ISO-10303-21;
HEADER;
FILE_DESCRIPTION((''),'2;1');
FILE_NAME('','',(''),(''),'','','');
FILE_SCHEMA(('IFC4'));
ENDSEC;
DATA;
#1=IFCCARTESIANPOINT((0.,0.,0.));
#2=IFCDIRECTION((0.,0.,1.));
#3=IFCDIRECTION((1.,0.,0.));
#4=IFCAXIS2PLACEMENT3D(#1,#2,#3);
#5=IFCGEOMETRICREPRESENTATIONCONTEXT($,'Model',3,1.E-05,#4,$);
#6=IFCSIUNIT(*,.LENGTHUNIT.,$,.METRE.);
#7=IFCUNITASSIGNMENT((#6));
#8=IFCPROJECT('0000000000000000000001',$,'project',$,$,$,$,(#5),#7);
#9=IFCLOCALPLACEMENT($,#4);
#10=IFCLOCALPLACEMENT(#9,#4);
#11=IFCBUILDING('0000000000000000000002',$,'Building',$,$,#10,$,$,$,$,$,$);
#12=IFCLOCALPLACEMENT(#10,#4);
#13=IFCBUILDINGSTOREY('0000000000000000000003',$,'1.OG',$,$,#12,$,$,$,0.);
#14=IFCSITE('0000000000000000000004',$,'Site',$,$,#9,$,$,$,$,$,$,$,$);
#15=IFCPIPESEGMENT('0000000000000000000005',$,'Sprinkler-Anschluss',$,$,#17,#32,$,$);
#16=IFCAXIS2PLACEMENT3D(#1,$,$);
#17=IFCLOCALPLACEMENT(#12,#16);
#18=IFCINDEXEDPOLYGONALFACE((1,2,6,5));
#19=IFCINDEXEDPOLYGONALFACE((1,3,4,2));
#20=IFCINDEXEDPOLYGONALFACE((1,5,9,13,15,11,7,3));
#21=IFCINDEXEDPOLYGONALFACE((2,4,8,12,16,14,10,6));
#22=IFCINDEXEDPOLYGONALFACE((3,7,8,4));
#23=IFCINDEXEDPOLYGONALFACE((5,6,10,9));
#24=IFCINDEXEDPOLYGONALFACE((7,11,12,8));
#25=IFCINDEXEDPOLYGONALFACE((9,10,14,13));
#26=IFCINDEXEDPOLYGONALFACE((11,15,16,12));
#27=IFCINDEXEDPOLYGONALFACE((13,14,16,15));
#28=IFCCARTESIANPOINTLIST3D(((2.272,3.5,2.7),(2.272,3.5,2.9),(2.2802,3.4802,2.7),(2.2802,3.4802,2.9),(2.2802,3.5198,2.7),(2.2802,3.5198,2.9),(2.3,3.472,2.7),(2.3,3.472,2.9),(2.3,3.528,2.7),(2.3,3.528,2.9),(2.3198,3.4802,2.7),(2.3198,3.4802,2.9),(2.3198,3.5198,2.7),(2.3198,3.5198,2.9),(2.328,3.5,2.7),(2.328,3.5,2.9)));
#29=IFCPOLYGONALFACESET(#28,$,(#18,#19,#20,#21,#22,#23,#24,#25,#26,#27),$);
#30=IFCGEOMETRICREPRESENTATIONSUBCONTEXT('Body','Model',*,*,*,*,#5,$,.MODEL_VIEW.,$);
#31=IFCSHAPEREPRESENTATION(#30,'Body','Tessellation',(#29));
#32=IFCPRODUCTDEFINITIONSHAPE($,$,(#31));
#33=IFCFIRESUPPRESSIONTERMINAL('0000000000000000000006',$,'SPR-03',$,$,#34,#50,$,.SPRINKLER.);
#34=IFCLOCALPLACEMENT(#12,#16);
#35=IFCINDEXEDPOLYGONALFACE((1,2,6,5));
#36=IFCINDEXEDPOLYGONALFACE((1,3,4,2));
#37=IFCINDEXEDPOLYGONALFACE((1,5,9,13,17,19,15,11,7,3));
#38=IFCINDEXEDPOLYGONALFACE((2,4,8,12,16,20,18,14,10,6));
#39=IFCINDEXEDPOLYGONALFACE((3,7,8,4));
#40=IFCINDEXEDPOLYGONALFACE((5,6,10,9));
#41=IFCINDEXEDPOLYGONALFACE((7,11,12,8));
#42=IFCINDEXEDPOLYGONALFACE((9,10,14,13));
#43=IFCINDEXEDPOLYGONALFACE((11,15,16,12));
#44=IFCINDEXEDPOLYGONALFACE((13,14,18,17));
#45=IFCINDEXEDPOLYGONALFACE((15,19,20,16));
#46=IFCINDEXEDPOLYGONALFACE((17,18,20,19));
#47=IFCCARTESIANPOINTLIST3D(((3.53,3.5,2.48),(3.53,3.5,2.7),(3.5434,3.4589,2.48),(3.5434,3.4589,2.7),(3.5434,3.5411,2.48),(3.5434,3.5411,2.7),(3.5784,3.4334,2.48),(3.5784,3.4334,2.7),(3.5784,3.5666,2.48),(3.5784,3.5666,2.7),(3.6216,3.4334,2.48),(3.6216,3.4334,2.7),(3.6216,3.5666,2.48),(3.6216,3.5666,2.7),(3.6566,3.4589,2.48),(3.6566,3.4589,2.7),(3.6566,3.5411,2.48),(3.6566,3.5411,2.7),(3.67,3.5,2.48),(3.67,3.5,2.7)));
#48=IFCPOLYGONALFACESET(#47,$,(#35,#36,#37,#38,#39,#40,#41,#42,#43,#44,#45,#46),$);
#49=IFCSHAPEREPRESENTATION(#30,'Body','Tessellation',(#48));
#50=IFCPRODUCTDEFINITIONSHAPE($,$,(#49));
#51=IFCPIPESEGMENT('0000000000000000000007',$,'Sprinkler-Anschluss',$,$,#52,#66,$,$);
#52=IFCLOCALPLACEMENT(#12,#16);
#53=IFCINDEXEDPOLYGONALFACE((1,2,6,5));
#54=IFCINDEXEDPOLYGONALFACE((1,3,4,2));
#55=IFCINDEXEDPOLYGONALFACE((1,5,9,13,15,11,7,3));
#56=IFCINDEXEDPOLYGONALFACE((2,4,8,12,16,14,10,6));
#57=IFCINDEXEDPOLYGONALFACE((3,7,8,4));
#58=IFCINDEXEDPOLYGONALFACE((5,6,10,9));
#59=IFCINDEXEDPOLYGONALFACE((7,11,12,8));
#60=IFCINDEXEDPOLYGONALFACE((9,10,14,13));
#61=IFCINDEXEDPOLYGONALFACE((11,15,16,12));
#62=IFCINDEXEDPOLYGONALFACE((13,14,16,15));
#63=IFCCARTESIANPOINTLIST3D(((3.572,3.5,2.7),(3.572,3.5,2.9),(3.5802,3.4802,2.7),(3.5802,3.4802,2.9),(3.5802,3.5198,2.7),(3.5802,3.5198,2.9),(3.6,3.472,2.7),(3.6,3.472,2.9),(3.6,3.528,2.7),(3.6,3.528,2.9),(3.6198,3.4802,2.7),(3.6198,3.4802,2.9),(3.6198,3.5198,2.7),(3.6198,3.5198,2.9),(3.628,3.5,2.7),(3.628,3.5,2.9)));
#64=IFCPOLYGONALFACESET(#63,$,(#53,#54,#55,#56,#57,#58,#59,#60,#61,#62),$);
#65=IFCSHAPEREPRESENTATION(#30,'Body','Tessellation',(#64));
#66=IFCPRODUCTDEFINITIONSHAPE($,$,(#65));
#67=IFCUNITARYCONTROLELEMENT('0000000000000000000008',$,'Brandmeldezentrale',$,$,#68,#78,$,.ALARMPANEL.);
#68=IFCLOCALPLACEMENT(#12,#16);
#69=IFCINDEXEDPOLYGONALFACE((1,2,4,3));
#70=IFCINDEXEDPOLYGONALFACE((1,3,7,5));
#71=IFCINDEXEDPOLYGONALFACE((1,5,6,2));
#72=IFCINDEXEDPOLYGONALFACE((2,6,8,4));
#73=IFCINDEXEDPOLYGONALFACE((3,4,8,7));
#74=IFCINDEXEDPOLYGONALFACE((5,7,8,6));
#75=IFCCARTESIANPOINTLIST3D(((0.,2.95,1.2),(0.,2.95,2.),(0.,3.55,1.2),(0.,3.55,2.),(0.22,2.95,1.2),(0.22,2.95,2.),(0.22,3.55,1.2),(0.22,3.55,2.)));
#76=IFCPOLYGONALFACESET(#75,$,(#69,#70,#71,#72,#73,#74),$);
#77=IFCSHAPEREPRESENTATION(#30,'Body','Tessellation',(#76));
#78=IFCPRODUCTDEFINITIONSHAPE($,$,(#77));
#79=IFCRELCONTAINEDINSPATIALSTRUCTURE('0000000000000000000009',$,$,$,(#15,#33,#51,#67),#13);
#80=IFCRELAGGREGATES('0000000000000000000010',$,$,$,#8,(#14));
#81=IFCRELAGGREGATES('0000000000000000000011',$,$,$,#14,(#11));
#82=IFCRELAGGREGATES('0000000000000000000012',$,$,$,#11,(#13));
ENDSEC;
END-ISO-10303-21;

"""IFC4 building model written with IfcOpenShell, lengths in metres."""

from ifc_helpers import new_model, si_unit, frame, origin_with_axes, place, context, subcontext, project, spatial, polyline, outline, extrude, element, save


model = new_model("IFC4")

# Units and contexts
model_context = context("Model", 3, precision=1e-05, world=origin_with_axes())
body_context = subcontext(model_context, "Body", "Model", "MODEL_VIEW")
ifc_project = project(units=[si_unit("LENGTHUNIT", "METRE")], contexts=[model_context])

# Site, building, storey
site_placement = place(None, origin_with_axes())
site = spatial("IfcSite", under=ifc_project, at=site_placement, Name="Site")
building_placement = place(site_placement, origin_with_axes())
building = spatial("IfcBuilding", under=site, at=building_placement, Name="Building")
storey_placement = place(building_placement, origin_with_axes())
storey = spatial("IfcBuildingStorey", under=building, at=storey_placement, Name="1.OG", Elevation=0.0)

# Pipe segment
pipe_segment_1_placement = place(storey_placement, origin_with_axes())
element("IfcPipeSegment", 1, at=pipe_segment_1_placement, inside=storey, Name="Sprinkler-Anschluss", context=body_context, shape_type="SweptSolid", body=[
    extrude(outline(polyline([(0.028, 0.0, 0.0), (0.0198, 0.0198, 0.0), (0.0, 0.028, 0.0), (-0.0198, 0.0198, 0.0), (-0.028, 0.0, 0.0), (-0.0198, -0.0198, 0.0), (0.0, -0.028, 0.0), (0.0198, -0.0198, 0.0), (0.028, 0.0, 0.0)])), frame((2.3, 3.5, 2.7), z_axis=(0.0, 0.0, 1.0), x_axis=(1.0, 0.0, 0.0)), (0.0, 0.0, 1.0), 0.2),
])

# Fire suppression terminal
fire_suppression_terminal_1_placement = place(storey_placement, origin_with_axes())
element("IfcFireSuppressionTerminal", 2, at=fire_suppression_terminal_1_placement, inside=storey, Name="SPR-03", PredefinedType="SPRINKLER", context=body_context, shape_type="SweptSolid", body=[
    extrude(outline(polyline([(0.07, 0.0, 0.0), (0.0566, 0.0411, 0.0), (0.0216, 0.0666, 0.0), (-0.0216, 0.0666, 0.0), (-0.0566, 0.0411, 0.0), (-0.07, 0.0, 0.0), (-0.0566, -0.0411, 0.0), (-0.0216, -0.0666, 0.0), (0.0216, -0.0666, 0.0), (0.0566, -0.0411, 0.0), (0.07, 0.0, 0.0)])), frame((3.6, 3.5, 2.48), z_axis=(0.0, 0.0, 1.0), x_axis=(1.0, 0.0, 0.0)), (0.0, 0.0, 1.0), 0.22),
])

# Pipe segment
pipe_segment_2_placement = place(storey_placement, origin_with_axes())
element("IfcPipeSegment", 3, at=pipe_segment_2_placement, inside=storey, Name="Sprinkler-Anschluss", context=body_context, shape_type="SweptSolid", body=[
    extrude(outline(polyline([(0.028, 0.0, 0.0), (0.0198, 0.0198, 0.0), (0.0, 0.028, 0.0), (-0.0198, 0.0198, 0.0), (-0.028, 0.0, 0.0), (-0.0198, -0.0198, 0.0), (0.0, -0.028, 0.0), (0.0198, -0.0198, 0.0), (0.028, 0.0, 0.0)])), frame((3.6, 3.5, 2.7), z_axis=(0.0, 0.0, 1.0), x_axis=(1.0, 0.0, 0.0)), (0.0, 0.0, 1.0), 0.2),
])

# Unitary control element
unitary_control_element_placement = place(storey_placement, origin_with_axes())
element("IfcUnitaryControlElement", 4, at=unitary_control_element_placement, inside=storey, Name="Brandmeldezentrale", PredefinedType="ALARMPANEL", context=body_context, shape_type="SweptSolid", body=[
    extrude(outline(polyline([(0.0, 2.95, 0.0), (0.22, 2.95, 0.0), (0.22, 3.55, 0.0), (0.0, 3.55, 0.0), (0.0, 2.95, 0.0)])), frame((0.0, 0.0, 1.2), z_axis=(0.0, 0.0, 1.0), x_axis=(1.0, 0.0, 0.0)), (0.0, 0.0, 1.0), 0.8),
])

save(model, "model.ifc")
